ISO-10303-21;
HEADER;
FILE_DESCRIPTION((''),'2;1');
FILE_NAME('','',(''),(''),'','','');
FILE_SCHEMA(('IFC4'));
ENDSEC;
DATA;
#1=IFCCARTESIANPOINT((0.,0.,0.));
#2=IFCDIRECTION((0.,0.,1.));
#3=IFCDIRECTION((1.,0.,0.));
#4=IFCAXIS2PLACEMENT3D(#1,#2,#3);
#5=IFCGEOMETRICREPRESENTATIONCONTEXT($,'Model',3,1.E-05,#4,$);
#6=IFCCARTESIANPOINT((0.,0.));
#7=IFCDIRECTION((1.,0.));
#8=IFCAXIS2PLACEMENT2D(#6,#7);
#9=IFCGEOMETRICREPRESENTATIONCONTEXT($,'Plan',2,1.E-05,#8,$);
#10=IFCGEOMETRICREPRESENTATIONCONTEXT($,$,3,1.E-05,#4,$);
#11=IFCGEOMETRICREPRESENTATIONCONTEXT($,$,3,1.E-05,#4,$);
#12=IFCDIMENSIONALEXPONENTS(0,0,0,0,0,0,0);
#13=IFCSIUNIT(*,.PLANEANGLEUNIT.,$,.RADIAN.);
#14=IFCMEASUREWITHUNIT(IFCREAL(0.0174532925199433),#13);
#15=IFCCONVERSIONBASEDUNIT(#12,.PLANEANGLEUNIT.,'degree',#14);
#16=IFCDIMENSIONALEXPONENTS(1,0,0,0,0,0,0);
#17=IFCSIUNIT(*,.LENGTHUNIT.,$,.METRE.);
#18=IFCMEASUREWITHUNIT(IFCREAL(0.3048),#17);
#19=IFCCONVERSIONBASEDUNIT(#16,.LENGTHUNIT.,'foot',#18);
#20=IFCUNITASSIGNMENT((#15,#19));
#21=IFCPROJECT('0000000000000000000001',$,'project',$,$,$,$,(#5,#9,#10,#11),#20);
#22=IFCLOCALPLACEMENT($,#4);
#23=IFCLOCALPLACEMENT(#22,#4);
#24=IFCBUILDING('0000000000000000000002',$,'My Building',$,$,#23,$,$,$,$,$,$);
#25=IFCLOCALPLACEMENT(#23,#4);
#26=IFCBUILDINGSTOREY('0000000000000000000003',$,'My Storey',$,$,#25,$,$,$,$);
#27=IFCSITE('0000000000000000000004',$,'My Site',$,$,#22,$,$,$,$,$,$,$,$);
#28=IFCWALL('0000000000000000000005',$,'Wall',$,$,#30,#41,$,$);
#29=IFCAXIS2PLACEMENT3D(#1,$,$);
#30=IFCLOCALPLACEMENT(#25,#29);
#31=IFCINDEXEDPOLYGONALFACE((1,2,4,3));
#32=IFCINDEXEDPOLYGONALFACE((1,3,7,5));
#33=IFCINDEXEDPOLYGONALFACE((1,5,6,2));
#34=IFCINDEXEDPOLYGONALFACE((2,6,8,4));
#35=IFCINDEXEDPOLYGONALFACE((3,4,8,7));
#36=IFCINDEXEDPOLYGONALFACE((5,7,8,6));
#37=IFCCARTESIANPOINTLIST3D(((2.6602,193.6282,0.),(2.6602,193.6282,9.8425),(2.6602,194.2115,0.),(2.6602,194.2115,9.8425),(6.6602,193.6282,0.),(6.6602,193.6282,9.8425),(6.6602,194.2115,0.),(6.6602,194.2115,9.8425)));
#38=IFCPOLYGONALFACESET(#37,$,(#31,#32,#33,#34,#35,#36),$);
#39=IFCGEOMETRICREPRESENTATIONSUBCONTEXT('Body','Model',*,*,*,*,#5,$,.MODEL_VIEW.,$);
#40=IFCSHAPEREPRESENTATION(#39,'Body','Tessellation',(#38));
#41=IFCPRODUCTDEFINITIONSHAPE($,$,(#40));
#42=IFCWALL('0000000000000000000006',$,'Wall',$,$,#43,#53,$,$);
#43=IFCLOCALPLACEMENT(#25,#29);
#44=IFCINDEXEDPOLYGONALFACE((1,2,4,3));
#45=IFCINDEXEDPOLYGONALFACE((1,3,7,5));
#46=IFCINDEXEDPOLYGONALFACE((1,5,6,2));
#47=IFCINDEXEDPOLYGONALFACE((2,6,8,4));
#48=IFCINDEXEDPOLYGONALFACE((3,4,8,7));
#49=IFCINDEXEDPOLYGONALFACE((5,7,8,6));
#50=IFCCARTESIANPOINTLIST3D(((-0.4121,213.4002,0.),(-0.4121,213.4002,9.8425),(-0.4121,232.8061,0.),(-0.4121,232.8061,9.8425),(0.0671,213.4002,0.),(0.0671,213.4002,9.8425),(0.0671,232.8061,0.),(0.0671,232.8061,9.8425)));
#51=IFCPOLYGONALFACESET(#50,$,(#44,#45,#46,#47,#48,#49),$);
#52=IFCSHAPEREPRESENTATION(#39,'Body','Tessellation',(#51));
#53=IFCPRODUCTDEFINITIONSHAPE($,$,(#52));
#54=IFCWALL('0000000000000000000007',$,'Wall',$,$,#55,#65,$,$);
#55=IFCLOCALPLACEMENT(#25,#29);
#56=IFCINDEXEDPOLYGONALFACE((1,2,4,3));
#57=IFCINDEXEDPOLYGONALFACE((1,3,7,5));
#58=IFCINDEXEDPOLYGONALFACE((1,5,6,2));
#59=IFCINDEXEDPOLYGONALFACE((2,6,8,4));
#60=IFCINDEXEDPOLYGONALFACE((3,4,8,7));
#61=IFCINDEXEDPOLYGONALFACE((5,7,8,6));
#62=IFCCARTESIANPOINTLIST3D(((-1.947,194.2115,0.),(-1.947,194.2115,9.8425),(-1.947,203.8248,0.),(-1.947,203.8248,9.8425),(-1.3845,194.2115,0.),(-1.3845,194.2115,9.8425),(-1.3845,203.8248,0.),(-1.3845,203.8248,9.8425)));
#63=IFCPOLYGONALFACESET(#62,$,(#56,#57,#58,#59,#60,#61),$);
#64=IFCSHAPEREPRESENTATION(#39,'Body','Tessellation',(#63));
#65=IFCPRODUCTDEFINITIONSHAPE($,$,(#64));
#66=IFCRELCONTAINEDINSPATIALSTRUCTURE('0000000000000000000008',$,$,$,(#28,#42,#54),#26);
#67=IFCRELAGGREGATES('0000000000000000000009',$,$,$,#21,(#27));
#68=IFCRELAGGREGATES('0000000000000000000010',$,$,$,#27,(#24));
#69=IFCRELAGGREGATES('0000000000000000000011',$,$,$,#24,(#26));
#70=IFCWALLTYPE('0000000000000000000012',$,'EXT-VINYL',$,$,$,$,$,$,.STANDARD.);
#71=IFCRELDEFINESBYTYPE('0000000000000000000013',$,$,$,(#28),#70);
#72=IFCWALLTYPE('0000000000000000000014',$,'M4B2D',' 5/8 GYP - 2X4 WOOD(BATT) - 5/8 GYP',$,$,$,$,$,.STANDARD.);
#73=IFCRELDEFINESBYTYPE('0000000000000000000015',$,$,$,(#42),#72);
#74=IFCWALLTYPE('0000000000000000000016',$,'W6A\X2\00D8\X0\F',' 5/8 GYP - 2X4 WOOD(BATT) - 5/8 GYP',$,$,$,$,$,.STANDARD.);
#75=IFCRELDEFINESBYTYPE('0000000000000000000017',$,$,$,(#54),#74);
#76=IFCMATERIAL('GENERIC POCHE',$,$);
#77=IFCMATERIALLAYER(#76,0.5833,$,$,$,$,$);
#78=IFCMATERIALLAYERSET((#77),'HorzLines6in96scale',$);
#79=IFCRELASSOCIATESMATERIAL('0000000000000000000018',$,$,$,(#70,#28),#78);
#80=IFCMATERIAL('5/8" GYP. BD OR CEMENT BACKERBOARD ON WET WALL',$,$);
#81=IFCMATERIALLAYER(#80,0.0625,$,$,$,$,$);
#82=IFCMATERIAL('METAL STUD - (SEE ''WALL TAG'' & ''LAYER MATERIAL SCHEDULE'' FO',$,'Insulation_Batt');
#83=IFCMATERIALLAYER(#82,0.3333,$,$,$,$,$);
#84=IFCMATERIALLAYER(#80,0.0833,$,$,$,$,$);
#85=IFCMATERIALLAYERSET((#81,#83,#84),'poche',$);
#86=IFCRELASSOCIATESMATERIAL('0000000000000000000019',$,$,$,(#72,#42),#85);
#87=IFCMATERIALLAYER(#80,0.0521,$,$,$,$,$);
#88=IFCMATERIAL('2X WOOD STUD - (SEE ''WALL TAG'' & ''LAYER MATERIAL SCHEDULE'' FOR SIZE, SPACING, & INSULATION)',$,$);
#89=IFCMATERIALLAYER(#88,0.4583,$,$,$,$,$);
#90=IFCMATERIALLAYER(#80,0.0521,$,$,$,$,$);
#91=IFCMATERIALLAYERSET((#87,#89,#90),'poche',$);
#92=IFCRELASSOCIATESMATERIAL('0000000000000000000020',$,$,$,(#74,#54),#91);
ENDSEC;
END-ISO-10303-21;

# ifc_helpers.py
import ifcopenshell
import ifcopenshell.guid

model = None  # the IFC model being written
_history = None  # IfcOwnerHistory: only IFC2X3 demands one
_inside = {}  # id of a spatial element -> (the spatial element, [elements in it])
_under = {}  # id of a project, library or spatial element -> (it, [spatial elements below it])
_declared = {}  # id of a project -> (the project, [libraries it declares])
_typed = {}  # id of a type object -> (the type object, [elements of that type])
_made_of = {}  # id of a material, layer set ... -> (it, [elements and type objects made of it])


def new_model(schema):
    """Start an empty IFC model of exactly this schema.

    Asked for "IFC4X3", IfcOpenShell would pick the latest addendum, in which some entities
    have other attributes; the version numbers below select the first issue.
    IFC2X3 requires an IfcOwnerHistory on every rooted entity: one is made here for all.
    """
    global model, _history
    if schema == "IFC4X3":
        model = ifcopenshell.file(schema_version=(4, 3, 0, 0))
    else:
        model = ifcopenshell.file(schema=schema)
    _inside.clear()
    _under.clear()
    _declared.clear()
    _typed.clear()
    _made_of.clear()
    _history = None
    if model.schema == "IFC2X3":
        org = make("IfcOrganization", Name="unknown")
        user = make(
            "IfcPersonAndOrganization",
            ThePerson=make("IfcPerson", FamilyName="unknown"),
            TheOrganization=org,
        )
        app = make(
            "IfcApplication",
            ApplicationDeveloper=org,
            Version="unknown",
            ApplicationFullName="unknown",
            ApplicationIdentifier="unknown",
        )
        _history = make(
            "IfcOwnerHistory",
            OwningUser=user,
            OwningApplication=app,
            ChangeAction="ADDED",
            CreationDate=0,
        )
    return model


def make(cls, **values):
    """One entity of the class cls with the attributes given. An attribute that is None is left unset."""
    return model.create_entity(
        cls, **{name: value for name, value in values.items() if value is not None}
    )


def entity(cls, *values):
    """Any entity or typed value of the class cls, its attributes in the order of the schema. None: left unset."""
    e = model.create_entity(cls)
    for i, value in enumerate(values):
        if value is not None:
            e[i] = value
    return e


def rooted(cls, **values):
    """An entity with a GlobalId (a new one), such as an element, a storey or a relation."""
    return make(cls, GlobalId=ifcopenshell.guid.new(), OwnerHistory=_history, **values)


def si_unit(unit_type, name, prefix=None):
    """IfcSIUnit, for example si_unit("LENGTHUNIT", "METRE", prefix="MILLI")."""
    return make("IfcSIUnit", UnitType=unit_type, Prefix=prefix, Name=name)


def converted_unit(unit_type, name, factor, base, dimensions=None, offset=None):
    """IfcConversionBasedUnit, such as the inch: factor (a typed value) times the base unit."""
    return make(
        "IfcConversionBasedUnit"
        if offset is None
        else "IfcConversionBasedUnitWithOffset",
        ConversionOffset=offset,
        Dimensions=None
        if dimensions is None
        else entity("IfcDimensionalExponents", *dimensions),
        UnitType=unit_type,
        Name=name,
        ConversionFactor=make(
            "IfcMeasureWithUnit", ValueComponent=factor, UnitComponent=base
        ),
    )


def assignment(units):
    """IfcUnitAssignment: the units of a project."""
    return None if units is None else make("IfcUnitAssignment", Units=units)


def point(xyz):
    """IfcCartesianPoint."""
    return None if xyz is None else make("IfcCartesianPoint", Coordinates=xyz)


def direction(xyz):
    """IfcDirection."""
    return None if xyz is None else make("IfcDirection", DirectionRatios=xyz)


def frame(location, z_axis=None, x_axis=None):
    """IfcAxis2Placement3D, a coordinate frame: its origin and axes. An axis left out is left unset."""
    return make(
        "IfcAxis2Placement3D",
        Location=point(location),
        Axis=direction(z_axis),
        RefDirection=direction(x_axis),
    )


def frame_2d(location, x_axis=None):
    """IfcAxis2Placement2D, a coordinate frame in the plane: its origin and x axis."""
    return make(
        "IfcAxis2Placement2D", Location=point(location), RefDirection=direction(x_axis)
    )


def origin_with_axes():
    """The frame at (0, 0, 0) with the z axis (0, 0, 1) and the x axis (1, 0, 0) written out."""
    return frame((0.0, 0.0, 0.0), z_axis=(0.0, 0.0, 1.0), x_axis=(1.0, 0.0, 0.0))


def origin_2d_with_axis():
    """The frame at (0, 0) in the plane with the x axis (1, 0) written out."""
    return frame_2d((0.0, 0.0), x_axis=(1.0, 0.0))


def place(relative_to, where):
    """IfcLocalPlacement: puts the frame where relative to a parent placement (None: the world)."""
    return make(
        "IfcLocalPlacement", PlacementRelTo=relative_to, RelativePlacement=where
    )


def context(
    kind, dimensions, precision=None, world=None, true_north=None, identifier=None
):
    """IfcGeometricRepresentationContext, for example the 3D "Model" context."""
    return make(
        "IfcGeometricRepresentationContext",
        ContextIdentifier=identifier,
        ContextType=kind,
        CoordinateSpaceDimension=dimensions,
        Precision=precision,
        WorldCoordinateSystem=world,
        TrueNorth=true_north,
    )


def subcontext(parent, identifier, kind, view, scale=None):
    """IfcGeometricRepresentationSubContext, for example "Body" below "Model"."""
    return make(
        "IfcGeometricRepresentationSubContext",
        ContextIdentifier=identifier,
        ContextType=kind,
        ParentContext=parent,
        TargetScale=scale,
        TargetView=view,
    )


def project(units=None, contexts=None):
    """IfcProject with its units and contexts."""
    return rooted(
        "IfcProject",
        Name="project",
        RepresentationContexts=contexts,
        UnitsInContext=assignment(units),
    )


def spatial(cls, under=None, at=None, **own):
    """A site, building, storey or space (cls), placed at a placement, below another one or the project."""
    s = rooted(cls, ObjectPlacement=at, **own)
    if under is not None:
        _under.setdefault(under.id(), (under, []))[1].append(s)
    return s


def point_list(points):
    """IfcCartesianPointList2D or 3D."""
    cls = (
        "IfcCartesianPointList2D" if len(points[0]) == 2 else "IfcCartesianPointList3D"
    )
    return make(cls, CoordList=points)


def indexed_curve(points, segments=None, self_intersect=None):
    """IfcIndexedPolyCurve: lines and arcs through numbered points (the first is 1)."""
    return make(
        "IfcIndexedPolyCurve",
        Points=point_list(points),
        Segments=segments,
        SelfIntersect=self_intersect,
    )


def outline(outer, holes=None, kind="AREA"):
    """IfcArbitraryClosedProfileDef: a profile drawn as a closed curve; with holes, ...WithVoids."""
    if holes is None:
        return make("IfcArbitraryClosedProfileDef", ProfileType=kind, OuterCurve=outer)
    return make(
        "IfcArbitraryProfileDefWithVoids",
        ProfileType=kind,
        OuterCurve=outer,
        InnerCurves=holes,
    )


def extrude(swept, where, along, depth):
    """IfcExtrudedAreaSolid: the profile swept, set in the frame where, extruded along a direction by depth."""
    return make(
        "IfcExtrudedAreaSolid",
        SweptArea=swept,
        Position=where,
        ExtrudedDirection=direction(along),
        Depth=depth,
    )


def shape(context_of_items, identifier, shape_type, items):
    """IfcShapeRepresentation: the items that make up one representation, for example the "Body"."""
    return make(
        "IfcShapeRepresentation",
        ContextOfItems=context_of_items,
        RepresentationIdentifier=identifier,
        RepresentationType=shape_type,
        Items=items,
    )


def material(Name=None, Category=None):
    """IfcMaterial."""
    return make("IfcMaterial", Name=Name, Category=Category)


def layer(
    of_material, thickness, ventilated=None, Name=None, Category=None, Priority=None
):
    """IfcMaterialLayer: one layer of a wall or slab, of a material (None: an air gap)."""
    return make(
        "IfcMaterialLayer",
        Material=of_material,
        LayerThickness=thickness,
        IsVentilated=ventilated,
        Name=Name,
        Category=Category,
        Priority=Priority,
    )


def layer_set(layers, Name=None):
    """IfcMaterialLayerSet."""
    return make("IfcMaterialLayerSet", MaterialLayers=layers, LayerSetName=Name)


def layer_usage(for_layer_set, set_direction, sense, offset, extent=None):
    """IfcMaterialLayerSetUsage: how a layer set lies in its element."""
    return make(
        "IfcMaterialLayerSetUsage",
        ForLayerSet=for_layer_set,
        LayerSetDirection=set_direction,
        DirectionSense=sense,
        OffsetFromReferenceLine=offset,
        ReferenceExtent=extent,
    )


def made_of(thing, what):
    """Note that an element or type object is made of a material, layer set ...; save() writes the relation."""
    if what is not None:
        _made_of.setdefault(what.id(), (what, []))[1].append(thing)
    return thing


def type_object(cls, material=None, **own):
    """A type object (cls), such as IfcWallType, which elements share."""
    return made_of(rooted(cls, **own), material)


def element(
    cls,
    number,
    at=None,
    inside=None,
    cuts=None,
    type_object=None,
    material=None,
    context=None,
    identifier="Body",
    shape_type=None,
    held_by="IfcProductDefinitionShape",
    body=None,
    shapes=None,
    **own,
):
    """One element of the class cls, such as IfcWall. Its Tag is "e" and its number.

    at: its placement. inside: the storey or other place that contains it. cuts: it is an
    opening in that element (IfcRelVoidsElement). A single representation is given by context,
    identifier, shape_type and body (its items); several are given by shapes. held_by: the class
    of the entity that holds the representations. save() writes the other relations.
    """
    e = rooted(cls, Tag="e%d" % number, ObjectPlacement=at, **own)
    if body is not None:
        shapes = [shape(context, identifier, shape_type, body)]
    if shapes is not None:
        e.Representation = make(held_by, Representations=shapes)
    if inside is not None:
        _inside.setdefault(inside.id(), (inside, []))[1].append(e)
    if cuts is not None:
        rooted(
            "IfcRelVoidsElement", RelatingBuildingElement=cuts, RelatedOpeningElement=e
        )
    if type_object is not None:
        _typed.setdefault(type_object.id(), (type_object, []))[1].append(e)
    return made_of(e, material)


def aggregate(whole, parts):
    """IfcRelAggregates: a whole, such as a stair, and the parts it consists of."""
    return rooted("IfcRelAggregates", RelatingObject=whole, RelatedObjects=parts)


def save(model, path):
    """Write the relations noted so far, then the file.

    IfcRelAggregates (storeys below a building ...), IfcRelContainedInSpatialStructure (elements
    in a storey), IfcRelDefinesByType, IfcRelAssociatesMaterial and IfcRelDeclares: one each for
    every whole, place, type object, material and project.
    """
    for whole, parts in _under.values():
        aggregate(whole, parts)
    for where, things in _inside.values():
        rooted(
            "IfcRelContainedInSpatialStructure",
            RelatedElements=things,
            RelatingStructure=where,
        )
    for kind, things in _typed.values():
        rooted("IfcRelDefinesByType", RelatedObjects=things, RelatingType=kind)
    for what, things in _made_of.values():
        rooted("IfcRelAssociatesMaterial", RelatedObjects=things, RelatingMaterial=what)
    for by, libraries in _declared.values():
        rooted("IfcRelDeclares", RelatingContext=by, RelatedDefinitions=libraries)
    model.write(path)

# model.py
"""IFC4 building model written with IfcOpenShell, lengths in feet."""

from ifc_helpers import new_model, entity, si_unit, converted_unit, frame, origin_with_axes, origin_2d_with_axis, place, context, subcontext, project, spatial, indexed_curve, outline, extrude, material, layer, layer_set, layer_usage, type_object, element, save


model = new_model("IFC4")

# Units and contexts
model_context = context("Model", 3, precision=1e-05, world=origin_with_axes())
plan_context = context("Plan", 2, precision=1e-05, world=origin_2d_with_axis())
context_of_model_1 = context(None, 3, precision=1e-05, world=origin_with_axes())
context_of_model_2 = context(None, 3, precision=1e-05, world=origin_with_axes())
body_context_1 = subcontext(model_context, "Body", "Model", "MODEL_VIEW")
ifc_project = project(units=[converted_unit("PLANEANGLEUNIT", "degree", entity("IfcReal", 0.0174532925199433), si_unit("PLANEANGLEUNIT", "RADIAN"), dimensions=[0, 0, 0, 0, 0, 0, 0]), converted_unit("LENGTHUNIT", "foot", entity("IfcReal", 0.3048), si_unit("LENGTHUNIT", "METRE"), dimensions=[1, 0, 0, 0, 0, 0, 0])], contexts=[model_context, plan_context, context_of_model_1, context_of_model_2])

# Site, building, storey
site_placement = place(None, origin_with_axes())
site = spatial("IfcSite", under=ifc_project, at=site_placement, Name="My Site")
building_placement = place(site_placement, origin_with_axes())
building = spatial("IfcBuilding", under=site, at=building_placement, Name="My Building")
storey_placement = place(building_placement, origin_with_axes())
storey = spatial("IfcBuildingStorey", under=building, at=storey_placement, Name="My Storey")

# Shared definitions
ifc_material_1 = material(Name="5/8\" GYP. BD OR CEMENT BACKERBOARD ON WET WALL")
ifc_material_2 = material(Name="2X WOOD STUD - (SEE 'WALL TAG' & 'LAYER MATERIAL SCHEDULE' FOR SIZE, SPACING, & INSULATION)")

# Walls
ifc_material_3 = material(Name="GENERIC POCHE")
ifc_layer_1 = layer(ifc_material_3, 0.5833)
ifc_layer_set_1 = layer_set([ifc_layer_1], Name="HorzLines6in96scale")
ifc_layer_usage_1 = layer_usage(ifc_layer_set_1, "AXIS2", "POSITIVE", 0.0)
wall_type_1 = type_object("IfcWallType", Name="EXT-VINYL", PredefinedType="STANDARD", material=ifc_layer_set_1)
wall_1_placement = place(storey_placement, frame((6.6602, 194.2115, 0.0), z_axis=(0.0, 0.0, 1.0), x_axis=(-1.0, 0.0, 0.0)))
element("IfcWall", 1, at=wall_1_placement, inside=storey, type_object=wall_type_1, material=ifc_layer_usage_1, Name="Wall", context=body_context_1, shape_type="SweptSolid", body=[
    extrude(outline(indexed_curve([(0.0, 0.0), (0.0, 0.5833), (4.0, 0.5833), (4.0, 0.0), (0.0, 0.0)], self_intersect=False)), origin_with_axes(), (0.0, 0.0, 1.0), 9.8425),
])
ifc_layer_2 = layer(ifc_material_1, 0.0625)
ifc_material_4 = material(Name="METAL STUD - (SEE 'WALL TAG' & 'LAYER MATERIAL SCHEDULE' FO", Category="Insulation_Batt")
ifc_layer_3 = layer(ifc_material_4, 0.3333)
ifc_layer_4 = layer(ifc_material_1, 0.0833)
ifc_layer_set_2 = layer_set([ifc_layer_2, ifc_layer_3, ifc_layer_4], Name="poche")
ifc_layer_usage_2 = layer_usage(ifc_layer_set_2, "AXIS2", "POSITIVE", 0.0)
wall_type_2 = type_object("IfcWallType", Name="M4B2D", Description=" 5/8 GYP - 2X4 WOOD(BATT) - 5/8 GYP", PredefinedType="STANDARD", material=ifc_layer_set_2)
wall_2_placement = place(storey_placement, frame((0.0671, 213.4002, 0.0), z_axis=(0.0, 0.0, 1.0), x_axis=(0.000001, 1.0, 0.0)))
element("IfcWall", 2, at=wall_2_placement, inside=storey, type_object=wall_type_2, material=ifc_layer_usage_2, Name="Wall", context=body_context_1, shape_type="SweptSolid", body=[
    extrude(outline(indexed_curve([(0.0, 0.0), (0.0, 0.4792), (19.4059, 0.4792), (19.4059, 0.0), (0.0, 0.0)], self_intersect=False)), origin_with_axes(), (0.0, 0.0, 1.0), 9.8425),
])
ifc_layer_5 = layer(ifc_material_1, 0.0521)
ifc_layer_6 = layer(ifc_material_2, 0.4583)
ifc_layer_7 = layer(ifc_material_1, 0.0521)
ifc_layer_set_3 = layer_set([ifc_layer_5, ifc_layer_6, ifc_layer_7], Name="poche")
ifc_layer_usage_3 = layer_usage(ifc_layer_set_3, "AXIS2", "POSITIVE", 0.0)
wall_type_3 = type_object("IfcWallType", Name="W6AØF", Description=" 5/8 GYP - 2X4 WOOD(BATT) - 5/8 GYP", PredefinedType="STANDARD", material=ifc_layer_set_3)
wall_3_placement = place(storey_placement, frame((-1.3845, 194.2115, 0.0), z_axis=(0.0, 0.0, 1.0), x_axis=(0.000001, 1.0, 0.0)))
element("IfcWall", 3, at=wall_3_placement, inside=storey, type_object=wall_type_3, material=ifc_layer_usage_3, Name="Wall", context=body_context_1, shape_type="SweptSolid", body=[
    extrude(outline(indexed_curve([(0.0, 0.0), (0.0, 0.5625), (9.6133, 0.5625), (9.6133, 0.0), (0.0, 0.0)], self_intersect=False)), origin_with_axes(), (0.0, 0.0, 1.0), 9.8425),
])

save(model, "model.ifc")
